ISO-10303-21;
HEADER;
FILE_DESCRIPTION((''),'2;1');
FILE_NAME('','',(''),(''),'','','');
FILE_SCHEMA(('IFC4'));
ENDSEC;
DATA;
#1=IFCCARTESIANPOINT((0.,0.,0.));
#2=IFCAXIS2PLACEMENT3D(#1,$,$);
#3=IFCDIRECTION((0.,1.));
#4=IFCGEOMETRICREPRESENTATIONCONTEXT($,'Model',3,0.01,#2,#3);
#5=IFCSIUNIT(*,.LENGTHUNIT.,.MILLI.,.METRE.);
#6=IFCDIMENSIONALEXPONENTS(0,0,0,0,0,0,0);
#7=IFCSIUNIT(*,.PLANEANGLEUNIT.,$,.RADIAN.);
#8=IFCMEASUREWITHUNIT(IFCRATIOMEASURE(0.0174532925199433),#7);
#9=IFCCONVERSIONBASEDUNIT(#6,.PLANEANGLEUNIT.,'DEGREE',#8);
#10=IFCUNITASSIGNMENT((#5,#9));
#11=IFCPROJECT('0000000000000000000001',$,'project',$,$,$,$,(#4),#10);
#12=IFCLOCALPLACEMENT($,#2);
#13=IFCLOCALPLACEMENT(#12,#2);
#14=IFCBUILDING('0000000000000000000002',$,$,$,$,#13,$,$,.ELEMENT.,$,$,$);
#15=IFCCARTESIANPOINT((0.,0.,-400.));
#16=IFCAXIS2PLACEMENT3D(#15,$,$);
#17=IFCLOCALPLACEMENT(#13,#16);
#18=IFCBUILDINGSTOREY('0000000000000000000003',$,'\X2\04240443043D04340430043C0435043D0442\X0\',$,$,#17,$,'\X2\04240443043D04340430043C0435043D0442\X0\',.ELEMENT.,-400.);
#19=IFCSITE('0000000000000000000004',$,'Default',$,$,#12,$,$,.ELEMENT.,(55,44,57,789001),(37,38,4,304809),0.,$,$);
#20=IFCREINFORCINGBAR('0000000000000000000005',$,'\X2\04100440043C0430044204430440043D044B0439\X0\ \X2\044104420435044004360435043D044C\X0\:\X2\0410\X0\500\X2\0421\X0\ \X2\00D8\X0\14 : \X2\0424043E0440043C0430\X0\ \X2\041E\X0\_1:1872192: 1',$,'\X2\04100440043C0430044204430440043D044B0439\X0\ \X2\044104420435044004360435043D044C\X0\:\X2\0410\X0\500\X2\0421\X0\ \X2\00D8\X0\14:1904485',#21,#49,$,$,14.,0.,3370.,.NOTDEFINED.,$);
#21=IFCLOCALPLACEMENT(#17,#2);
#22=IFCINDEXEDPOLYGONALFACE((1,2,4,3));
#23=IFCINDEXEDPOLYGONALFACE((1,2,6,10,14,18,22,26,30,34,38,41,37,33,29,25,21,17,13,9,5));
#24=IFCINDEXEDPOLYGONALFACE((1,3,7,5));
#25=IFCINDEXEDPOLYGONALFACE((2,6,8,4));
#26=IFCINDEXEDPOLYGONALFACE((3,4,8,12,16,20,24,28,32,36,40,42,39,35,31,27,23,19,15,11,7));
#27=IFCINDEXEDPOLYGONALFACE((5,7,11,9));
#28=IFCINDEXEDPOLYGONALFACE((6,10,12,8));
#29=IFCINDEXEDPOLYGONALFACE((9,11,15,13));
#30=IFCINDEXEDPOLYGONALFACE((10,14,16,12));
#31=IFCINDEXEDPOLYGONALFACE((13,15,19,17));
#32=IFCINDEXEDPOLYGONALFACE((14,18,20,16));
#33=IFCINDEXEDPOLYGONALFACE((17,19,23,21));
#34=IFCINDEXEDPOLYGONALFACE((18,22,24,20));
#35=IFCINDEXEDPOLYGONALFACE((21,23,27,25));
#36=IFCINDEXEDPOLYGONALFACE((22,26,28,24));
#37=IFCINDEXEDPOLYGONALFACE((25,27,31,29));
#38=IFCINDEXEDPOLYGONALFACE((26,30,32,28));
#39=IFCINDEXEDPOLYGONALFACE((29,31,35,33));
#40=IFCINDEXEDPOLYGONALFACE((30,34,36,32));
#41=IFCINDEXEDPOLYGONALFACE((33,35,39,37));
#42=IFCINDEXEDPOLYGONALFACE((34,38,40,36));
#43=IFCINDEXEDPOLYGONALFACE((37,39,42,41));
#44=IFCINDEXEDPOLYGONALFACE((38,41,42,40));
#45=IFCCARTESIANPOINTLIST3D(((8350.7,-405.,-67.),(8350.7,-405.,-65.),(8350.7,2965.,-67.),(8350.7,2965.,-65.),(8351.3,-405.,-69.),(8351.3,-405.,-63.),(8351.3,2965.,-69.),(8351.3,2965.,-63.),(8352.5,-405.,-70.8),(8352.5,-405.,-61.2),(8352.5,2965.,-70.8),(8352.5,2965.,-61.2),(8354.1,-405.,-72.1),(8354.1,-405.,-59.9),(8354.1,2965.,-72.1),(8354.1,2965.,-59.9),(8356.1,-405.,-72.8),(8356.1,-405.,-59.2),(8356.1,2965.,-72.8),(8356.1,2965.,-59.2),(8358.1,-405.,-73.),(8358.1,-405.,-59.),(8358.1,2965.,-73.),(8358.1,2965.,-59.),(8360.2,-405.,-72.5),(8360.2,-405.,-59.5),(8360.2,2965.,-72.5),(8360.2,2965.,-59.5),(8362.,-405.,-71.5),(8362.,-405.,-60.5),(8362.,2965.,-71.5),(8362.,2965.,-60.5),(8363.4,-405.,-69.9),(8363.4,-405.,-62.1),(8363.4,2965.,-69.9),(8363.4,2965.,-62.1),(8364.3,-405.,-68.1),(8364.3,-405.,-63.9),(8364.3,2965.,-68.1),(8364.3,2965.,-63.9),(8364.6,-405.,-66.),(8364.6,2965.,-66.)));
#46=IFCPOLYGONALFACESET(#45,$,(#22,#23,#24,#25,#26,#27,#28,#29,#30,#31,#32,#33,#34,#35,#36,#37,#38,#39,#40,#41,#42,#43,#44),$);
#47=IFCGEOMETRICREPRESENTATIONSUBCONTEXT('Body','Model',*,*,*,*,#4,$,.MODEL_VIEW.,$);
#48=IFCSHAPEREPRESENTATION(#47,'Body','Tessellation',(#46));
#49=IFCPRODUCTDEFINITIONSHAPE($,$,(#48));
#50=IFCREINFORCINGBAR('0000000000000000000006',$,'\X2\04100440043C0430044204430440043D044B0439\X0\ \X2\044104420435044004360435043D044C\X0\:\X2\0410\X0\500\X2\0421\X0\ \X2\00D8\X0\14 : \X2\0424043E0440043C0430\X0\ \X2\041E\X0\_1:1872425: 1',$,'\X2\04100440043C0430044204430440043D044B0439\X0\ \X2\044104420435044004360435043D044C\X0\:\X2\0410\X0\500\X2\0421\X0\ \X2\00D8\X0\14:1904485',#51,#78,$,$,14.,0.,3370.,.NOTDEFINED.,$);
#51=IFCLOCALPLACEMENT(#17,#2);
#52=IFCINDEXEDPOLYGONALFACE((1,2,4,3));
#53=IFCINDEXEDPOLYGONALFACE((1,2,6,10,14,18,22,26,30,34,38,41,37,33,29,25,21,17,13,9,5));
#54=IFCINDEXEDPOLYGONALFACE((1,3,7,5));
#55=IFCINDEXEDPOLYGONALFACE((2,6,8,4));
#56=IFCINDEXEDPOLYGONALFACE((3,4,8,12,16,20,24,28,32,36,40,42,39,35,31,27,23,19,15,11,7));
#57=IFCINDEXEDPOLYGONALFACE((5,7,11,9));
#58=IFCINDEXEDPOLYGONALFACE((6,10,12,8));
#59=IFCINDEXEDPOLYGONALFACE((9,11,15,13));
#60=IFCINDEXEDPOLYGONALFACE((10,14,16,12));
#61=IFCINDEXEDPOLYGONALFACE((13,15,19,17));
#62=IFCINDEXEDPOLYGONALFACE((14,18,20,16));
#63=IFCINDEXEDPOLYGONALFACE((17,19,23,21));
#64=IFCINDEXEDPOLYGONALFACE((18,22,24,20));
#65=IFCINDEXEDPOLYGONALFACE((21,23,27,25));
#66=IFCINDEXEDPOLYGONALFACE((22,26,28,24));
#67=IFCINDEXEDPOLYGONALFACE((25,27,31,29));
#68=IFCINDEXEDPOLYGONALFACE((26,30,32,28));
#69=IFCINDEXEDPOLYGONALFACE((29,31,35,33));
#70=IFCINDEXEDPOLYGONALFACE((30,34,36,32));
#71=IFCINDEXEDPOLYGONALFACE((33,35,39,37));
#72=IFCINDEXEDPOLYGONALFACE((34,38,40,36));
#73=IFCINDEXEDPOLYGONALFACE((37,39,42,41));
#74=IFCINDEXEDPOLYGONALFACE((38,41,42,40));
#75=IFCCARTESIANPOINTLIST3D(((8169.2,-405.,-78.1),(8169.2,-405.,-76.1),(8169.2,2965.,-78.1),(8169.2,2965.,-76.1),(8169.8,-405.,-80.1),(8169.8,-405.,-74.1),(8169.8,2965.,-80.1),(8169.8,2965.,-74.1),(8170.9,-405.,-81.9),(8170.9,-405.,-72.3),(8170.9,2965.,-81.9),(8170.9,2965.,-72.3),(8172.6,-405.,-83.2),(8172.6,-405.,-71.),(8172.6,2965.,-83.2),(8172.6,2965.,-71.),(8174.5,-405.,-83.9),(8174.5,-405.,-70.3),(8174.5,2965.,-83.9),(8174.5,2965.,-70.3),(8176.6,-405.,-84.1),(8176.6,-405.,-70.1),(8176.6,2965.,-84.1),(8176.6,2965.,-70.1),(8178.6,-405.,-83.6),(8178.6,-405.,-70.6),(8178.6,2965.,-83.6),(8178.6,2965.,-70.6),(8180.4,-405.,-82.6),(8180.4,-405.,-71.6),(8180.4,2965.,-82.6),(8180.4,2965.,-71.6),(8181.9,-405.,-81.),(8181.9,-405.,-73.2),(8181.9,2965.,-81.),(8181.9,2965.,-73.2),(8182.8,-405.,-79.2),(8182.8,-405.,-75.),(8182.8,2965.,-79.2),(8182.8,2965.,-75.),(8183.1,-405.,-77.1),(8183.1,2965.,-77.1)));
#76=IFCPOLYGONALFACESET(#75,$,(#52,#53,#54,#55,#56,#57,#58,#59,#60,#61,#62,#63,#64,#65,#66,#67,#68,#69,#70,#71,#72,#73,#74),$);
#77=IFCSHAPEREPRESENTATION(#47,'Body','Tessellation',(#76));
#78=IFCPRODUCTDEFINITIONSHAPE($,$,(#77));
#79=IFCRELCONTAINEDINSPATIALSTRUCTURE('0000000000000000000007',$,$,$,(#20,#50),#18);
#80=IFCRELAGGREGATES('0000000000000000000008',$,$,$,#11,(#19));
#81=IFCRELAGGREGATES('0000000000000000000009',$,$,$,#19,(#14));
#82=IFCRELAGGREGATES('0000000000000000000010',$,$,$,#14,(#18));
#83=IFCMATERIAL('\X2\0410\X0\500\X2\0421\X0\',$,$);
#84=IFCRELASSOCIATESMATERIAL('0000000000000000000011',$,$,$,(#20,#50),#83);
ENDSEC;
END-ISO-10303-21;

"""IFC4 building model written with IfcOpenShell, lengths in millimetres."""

from ifc_helpers import new_model, entity, si_unit, converted_unit, direction, frame, origin, place, context, subcontext, project, spatial, material, element, save


model = new_model("IFC4")

# Units and contexts
model_context = context("Model", 3, precision=0.01, world=origin(), true_north=direction((0.0, 1.0)))
body_context = subcontext(model_context, "Body", "Model", "MODEL_VIEW")
ifc_project = project(units=[si_unit("LENGTHUNIT", "METRE", prefix="MILLI"), converted_unit("PLANEANGLEUNIT", "DEGREE", entity("IfcRatioMeasure", 0.0174532925199433), si_unit("PLANEANGLEUNIT", "RADIAN"), dimensions=[0, 0, 0, 0, 0, 0, 0])], contexts=[model_context])

# Site, building, storey
site_placement = place(None, origin())
site = spatial("IfcSite", under=ifc_project, at=site_placement, Name="Default", CompositionType="ELEMENT", RefLatitude=(55, 44, 57, 789001), RefLongitude=(37, 38, 4, 304809), RefElevation=0.0)
building_placement = place(site_placement, origin())
building = spatial("IfcBuilding", under=site, at=building_placement, CompositionType="ELEMENT")
storey_placement = place(building_placement, frame((0.0, 0.0, -400.0)))
storey = spatial("IfcBuildingStorey", under=building, at=storey_placement, Name="Фундамент", LongName="Фундамент", CompositionType="ELEMENT", Elevation=-400.0)

# Reinforcing bars
ifc_material_1 = material(Name="А500С")
reinforcing_bar_1_placement = place(storey_placement, origin())
element("IfcReinforcingBar", 1, at=reinforcing_bar_1_placement, inside=storey, material=ifc_material_1, Name="Арматурный стержень:А500С Ø14 : Форма О_1:1872192: 1", ObjectType="Арматурный стержень:А500С Ø14:1904485", BarLength=3370.0, CrossSectionArea=0.0, NominalDiameter=14.0, PredefinedType="NOTDEFINED", context=body_context, shape_type="AdvancedSweptSolid", body=[
    entity("IfcSweptDiskSolid", entity("IfcCompositeCurve", [entity("IfcCompositeCurveSegment", "CONTINUOUS", True, entity("IfcPolyline", [entity("IfcCartesianPoint", [8357.6, -405.0, -66.0]), entity("IfcCartesianPoint", [8357.6, 2965.0, -66.0])]))], False), 7.0, None, 0.0, 1.0),
])
reinforcing_bar_2_placement = place(storey_placement, origin())
element("IfcReinforcingBar", 2, at=reinforcing_bar_2_placement, inside=storey, material=ifc_material_1, Name="Арматурный стержень:А500С Ø14 : Форма О_1:1872425: 1", ObjectType="Арматурный стержень:А500С Ø14:1904485", BarLength=3370.0, CrossSectionArea=0.0, NominalDiameter=14.0, PredefinedType="NOTDEFINED", context=body_context, shape_type="AdvancedSweptSolid", body=[
    entity("IfcSweptDiskSolid", entity("IfcCompositeCurve", [entity("IfcCompositeCurveSegment", "CONTINUOUS", True, entity("IfcPolyline", [entity("IfcCartesianPoint", [8176.1, -405.0, -77.1]), entity("IfcCartesianPoint", [8176.1, 2965.0, -77.1])]))], False), 7.0, None, 0.0, 1.0),
])

save(model, "model.ifc")
